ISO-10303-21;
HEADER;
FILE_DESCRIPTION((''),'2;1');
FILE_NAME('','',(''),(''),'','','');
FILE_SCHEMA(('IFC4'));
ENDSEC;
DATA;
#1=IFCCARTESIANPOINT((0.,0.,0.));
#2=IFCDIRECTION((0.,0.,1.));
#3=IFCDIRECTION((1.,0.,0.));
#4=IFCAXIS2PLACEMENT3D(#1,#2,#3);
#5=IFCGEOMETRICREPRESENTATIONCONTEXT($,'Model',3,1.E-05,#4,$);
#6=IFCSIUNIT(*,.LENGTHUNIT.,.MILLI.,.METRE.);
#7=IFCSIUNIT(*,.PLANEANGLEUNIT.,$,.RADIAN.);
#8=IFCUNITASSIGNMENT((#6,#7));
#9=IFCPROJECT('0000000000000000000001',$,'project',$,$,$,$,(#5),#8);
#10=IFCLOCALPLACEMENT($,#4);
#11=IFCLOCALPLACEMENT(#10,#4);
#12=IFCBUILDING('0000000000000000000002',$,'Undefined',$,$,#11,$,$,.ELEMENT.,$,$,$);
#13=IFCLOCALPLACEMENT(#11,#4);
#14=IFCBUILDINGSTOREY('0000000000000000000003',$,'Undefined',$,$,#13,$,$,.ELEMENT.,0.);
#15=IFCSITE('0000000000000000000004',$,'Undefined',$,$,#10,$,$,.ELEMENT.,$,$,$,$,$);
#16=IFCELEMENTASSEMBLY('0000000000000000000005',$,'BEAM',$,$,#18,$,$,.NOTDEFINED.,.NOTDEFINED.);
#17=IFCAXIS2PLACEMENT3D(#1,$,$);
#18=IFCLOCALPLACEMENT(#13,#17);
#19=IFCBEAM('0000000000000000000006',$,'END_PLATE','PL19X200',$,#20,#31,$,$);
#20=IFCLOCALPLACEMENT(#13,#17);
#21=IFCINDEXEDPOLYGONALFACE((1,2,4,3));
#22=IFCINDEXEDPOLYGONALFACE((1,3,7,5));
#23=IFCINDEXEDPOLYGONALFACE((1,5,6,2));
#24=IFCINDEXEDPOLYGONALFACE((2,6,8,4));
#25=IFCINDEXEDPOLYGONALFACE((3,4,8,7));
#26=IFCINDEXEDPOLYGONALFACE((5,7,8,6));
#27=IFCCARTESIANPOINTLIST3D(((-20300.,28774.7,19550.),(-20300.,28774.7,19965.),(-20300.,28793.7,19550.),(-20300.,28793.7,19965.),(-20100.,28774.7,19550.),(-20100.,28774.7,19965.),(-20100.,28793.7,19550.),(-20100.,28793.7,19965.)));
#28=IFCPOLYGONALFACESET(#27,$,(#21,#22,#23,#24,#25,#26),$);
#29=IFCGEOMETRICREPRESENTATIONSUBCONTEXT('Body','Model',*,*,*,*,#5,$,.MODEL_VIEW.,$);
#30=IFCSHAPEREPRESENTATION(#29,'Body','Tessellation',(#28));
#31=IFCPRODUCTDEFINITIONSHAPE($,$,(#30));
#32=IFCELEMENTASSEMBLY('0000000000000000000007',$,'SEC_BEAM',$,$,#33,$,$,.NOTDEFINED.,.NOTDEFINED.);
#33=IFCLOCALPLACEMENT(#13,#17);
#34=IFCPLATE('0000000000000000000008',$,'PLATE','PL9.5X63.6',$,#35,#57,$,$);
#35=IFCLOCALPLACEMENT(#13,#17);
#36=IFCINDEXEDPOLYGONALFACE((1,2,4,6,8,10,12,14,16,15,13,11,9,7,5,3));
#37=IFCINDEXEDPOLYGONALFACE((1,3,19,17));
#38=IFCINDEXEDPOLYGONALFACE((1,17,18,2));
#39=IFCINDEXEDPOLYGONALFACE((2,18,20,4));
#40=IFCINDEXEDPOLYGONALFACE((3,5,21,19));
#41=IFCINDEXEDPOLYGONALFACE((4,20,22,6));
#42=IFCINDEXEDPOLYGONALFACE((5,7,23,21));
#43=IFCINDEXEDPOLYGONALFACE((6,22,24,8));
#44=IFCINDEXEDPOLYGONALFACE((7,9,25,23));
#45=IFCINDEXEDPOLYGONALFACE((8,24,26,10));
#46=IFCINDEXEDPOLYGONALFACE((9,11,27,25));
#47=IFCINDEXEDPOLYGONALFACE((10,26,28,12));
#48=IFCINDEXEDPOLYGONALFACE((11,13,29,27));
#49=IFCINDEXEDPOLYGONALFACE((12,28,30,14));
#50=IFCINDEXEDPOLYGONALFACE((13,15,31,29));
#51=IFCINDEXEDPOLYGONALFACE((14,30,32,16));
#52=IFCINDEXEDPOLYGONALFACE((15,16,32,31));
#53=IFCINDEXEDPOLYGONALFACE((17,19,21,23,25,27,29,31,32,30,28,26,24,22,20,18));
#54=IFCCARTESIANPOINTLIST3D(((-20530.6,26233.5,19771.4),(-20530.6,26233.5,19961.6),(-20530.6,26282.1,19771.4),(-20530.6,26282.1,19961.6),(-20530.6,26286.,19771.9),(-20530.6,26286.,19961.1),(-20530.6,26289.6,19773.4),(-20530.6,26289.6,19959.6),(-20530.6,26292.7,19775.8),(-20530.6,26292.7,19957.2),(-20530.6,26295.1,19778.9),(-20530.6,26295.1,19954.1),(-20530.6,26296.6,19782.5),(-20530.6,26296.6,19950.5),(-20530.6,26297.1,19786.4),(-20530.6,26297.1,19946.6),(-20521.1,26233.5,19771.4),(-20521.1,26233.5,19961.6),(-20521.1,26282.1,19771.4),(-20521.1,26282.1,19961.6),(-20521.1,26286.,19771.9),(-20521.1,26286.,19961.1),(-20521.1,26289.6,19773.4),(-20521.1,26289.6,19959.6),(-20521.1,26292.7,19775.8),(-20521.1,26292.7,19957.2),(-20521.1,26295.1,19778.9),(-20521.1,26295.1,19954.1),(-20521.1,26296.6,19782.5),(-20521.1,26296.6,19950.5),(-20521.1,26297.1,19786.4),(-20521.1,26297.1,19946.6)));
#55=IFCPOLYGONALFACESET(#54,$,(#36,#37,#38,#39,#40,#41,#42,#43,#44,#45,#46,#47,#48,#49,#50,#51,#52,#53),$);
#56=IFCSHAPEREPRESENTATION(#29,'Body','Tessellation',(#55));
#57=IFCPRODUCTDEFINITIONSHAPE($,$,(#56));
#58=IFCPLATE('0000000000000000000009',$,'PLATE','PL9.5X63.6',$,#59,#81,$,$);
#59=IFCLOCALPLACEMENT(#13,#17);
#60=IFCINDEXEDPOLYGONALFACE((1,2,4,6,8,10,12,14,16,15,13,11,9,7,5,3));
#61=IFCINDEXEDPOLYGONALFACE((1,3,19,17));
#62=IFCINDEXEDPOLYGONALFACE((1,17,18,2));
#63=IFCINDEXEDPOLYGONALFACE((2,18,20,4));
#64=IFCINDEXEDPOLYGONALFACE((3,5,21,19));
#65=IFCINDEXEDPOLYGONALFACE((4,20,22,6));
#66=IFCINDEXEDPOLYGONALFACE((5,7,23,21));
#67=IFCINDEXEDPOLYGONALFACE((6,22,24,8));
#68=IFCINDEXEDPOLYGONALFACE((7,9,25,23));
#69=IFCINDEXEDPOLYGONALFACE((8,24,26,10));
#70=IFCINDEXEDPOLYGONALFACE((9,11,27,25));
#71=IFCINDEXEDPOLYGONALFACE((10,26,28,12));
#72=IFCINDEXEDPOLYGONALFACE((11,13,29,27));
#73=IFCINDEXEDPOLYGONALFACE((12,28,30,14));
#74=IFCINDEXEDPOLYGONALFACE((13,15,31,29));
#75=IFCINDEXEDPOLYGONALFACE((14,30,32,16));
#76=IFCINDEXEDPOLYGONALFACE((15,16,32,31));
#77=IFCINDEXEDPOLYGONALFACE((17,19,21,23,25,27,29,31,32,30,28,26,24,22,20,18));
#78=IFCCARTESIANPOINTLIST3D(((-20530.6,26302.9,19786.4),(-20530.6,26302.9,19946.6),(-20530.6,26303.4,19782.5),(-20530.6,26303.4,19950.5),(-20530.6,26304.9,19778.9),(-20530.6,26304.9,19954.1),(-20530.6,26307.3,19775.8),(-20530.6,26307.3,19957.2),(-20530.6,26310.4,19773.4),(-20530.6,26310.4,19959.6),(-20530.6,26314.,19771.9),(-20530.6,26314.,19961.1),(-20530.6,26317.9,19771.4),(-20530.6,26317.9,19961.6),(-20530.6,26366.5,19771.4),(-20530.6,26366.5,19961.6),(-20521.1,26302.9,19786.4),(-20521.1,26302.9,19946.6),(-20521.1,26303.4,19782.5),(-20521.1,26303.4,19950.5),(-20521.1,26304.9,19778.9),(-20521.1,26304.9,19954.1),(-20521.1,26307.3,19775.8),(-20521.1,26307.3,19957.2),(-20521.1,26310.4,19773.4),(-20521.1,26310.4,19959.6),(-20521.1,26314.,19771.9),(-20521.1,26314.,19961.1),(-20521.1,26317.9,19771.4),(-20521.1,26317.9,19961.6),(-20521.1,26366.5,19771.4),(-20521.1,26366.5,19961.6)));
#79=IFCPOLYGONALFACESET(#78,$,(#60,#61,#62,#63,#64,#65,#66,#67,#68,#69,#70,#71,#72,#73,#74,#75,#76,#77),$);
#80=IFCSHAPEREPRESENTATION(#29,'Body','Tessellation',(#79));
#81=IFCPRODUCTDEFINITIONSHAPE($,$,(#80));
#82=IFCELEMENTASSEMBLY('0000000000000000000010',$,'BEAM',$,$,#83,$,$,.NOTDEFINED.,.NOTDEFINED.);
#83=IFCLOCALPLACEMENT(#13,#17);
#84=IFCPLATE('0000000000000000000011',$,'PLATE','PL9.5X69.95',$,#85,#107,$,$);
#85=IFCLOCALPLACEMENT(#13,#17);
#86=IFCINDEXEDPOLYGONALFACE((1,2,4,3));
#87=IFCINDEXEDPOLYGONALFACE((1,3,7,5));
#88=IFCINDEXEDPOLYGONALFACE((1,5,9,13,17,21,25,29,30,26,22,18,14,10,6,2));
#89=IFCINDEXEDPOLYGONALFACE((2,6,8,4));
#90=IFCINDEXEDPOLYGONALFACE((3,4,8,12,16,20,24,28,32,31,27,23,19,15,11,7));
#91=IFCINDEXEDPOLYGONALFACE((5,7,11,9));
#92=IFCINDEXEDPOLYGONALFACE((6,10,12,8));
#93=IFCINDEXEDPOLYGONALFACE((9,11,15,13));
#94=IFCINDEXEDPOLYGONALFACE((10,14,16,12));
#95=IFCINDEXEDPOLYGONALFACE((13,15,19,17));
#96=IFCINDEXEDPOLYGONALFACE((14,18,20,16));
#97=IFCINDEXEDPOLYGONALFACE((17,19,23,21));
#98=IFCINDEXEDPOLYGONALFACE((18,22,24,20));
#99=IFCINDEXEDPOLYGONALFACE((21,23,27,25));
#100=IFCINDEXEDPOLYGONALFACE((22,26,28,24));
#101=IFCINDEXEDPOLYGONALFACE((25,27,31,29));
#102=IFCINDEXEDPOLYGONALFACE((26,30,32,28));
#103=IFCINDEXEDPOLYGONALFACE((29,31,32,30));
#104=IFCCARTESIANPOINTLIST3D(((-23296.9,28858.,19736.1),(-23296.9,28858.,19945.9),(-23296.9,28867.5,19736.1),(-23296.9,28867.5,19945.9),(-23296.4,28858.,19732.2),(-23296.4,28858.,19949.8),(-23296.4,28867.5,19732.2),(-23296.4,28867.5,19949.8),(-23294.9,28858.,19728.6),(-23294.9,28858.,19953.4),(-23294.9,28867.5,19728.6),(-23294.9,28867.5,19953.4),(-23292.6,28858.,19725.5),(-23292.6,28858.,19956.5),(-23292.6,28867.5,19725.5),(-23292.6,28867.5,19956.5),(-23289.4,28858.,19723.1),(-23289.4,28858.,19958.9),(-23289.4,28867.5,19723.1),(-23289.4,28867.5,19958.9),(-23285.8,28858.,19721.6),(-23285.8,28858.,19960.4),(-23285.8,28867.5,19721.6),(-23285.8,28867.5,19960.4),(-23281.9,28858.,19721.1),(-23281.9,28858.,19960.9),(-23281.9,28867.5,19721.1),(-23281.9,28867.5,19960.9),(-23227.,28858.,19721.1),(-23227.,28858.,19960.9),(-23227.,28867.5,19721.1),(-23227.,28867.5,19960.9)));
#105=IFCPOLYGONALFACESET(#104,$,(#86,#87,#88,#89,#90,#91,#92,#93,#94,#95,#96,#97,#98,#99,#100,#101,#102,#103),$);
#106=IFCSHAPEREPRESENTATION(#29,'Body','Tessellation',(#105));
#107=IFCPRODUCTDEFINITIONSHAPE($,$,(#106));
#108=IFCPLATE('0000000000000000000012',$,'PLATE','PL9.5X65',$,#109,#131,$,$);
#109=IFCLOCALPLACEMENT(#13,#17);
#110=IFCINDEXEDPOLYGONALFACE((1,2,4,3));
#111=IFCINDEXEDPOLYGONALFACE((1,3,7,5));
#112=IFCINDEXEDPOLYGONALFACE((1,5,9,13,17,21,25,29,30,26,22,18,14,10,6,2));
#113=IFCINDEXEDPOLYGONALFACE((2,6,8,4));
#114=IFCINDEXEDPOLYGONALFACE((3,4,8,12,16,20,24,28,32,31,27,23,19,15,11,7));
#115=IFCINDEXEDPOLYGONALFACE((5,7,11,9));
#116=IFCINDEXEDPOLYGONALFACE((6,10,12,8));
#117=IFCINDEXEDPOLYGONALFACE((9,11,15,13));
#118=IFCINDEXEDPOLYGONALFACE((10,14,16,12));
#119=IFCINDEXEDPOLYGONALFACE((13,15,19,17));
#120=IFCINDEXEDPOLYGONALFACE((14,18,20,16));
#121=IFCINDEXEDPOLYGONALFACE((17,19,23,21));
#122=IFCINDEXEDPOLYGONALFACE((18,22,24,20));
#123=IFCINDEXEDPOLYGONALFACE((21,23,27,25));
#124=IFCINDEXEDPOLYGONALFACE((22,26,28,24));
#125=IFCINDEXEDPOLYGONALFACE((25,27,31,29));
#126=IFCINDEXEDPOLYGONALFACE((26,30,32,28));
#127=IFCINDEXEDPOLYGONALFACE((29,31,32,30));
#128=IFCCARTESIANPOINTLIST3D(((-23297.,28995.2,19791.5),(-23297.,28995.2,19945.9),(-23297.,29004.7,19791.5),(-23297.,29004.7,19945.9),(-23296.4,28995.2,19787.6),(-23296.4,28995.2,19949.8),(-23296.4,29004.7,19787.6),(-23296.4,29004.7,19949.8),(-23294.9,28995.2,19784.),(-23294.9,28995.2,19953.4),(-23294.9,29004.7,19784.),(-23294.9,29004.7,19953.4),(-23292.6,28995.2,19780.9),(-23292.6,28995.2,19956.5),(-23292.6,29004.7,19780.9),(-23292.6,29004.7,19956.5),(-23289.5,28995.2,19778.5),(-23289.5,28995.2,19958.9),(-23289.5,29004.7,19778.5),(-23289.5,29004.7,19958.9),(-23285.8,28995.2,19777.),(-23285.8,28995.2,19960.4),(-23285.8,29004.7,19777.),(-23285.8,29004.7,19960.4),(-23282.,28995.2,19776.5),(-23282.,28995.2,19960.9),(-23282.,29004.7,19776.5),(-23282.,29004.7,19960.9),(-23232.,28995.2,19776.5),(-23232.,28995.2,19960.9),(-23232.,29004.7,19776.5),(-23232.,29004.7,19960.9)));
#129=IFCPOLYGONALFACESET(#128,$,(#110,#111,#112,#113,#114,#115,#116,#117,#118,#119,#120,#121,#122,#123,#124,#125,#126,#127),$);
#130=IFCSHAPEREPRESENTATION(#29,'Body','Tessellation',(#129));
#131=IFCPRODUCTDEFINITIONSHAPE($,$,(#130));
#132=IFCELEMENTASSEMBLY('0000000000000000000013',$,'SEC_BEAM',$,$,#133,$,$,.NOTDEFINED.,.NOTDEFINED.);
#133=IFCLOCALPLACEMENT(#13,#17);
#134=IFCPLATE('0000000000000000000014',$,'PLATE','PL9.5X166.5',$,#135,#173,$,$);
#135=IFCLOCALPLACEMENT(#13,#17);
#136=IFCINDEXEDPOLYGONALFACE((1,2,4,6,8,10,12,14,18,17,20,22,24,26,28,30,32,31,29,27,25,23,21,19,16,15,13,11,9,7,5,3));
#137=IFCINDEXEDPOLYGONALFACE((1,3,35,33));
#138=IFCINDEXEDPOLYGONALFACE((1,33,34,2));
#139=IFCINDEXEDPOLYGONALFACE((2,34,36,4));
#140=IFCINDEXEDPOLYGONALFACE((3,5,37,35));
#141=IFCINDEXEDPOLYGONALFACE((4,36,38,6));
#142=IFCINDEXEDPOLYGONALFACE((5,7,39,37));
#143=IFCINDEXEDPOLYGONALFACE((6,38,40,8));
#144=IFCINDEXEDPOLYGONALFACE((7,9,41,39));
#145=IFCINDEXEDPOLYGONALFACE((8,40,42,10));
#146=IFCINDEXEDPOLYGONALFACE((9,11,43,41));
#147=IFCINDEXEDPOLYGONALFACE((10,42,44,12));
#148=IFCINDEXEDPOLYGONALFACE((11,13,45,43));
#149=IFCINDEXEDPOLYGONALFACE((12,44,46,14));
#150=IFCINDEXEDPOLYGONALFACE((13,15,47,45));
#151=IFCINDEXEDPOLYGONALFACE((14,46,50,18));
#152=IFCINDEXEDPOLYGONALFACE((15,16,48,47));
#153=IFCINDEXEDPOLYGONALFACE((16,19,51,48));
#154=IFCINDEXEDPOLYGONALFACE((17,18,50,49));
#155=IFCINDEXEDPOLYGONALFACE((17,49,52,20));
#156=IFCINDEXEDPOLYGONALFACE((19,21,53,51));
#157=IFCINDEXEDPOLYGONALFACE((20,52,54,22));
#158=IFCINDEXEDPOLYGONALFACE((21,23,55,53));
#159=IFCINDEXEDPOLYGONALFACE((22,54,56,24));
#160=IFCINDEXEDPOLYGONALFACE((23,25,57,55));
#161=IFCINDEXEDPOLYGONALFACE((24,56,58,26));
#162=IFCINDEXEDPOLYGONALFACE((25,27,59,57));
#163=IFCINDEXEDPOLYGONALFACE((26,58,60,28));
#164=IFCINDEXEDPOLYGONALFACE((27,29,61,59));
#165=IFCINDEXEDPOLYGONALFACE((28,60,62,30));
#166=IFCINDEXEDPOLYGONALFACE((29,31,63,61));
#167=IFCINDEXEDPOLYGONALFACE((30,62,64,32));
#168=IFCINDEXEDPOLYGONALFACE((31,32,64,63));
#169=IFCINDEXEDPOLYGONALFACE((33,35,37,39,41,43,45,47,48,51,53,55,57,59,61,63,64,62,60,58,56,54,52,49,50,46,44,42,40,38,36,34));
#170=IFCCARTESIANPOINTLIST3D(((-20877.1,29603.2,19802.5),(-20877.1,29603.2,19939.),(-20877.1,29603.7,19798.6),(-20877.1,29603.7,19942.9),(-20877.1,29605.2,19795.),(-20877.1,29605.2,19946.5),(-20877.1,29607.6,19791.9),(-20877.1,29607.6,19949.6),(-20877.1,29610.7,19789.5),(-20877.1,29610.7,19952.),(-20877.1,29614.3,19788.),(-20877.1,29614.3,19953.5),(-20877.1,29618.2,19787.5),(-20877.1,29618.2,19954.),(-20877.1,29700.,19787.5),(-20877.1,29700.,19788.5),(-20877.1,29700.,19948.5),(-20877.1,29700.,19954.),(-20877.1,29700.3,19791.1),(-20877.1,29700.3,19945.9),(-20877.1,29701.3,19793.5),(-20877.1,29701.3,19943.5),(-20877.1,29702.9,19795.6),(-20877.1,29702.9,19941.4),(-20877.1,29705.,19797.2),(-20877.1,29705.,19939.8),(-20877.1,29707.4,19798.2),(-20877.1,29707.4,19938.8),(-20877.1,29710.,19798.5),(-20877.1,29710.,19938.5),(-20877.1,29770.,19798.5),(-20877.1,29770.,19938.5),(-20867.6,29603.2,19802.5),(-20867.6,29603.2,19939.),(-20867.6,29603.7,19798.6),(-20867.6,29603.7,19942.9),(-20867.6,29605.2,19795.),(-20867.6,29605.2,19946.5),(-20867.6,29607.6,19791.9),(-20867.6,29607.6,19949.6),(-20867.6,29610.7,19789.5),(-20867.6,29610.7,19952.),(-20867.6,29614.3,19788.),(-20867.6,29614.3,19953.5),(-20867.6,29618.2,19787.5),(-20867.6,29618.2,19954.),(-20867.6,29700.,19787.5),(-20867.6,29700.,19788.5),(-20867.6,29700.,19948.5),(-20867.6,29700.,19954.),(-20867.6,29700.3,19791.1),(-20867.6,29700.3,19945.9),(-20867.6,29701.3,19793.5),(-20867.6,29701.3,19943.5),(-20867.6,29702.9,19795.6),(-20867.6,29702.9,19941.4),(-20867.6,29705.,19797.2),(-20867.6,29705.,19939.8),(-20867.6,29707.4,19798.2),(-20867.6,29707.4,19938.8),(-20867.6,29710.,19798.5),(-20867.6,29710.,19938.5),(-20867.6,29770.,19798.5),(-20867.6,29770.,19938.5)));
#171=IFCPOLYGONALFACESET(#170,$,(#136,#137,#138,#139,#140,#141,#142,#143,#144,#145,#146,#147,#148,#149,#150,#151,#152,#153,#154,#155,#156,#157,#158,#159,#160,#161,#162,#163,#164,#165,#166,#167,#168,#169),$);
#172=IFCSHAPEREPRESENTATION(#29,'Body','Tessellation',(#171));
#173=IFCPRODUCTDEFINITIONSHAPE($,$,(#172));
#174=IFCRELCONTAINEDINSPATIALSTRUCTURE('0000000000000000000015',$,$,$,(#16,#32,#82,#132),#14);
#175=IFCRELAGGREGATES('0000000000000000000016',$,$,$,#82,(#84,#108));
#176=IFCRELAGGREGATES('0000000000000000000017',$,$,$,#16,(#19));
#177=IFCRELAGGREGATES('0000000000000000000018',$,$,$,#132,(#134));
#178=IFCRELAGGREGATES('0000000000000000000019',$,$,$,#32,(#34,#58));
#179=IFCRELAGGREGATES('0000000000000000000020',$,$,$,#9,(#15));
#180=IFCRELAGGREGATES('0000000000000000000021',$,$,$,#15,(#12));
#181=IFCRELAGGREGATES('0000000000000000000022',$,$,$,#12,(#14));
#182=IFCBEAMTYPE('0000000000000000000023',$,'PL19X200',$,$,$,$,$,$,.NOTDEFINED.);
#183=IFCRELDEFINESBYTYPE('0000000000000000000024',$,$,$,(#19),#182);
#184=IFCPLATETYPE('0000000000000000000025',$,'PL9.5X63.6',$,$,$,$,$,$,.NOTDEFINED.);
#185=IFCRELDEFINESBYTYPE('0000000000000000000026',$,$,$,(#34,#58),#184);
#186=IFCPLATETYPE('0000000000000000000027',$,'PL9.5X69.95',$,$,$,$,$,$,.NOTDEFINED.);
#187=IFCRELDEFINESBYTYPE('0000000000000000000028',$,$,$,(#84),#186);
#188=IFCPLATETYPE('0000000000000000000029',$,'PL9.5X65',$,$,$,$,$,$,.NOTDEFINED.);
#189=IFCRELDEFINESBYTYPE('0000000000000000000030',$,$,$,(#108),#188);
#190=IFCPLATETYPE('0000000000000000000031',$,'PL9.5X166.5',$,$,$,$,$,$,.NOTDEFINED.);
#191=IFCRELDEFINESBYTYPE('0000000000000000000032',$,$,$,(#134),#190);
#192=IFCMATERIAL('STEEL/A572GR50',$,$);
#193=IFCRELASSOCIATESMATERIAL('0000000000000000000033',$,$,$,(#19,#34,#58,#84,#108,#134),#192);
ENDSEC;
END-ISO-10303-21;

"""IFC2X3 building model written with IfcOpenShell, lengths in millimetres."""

from ifc_helpers import new_model, si_unit, frame, frame_2d, origin_with_axes, origin_2d_with_axis, place, context, subcontext, project, spatial, polyline, circle_curve, parameter, trimmed, segment, composite_curve, rectangle, outline, extrude, material, type_object, element, aggregate, save


model = new_model("IFC2X3")

# Units and contexts
model_context = context("Model", 3, precision=1e-05, world=origin_with_axes())
body_context = subcontext(model_context, "Body", "Model", "MODEL_VIEW")
ifc_project = project(units=[si_unit("LENGTHUNIT", "METRE", prefix="MILLI"), si_unit("PLANEANGLEUNIT", "RADIAN")], contexts=[model_context])

# Site, building, storey
site_placement = place(None, origin_with_axes())
site = spatial("IfcSite", under=ifc_project, at=site_placement, Name="Undefined", CompositionType="ELEMENT")
building_placement = place(site_placement, origin_with_axes())
building = spatial("IfcBuilding", under=site, at=building_placement, Name="Undefined", CompositionType="ELEMENT")
storey_placement = place(building_placement, origin_with_axes())
storey = spatial("IfcBuildingStorey", under=building, at=storey_placement, Name="Undefined", CompositionType="ELEMENT", Elevation=0.0)

# Element assemblies, beam
assembly_1_placement = place(storey_placement, origin_with_axes())
assembly_1 = element("IfcElementAssembly", 1, at=assembly_1_placement, inside=storey, Name="BEAM", AssemblyPlace="NOTDEFINED", PredefinedType="NOTDEFINED")
ifc_material_1 = material(Name="STEEL/A572GR50")
beam_type_1 = type_object("IfcBeamType", Name="PL19X200", PredefinedType="NOTDEFINED")
beam_1_placement = place(assembly_1_placement, frame((-20200.0, 28784.2, 19965.0), z_axis=(-1.0, 0.0, 0.0), x_axis=(0.0, 0.0, -1.0)))
beam_1 = element("IfcBeam", 2, at=beam_1_placement, type_object=beam_type_1, material=ifc_material_1, Name="END_PLATE", Description="PL19X200", context=body_context, shape_type="SweptSolid", body=[
    extrude(rectangle(XDim=19.0, YDim=200.0, at=origin_2d_with_axis()), frame((415.0, 0.0, 0.0), z_axis=(-1.0, 0.0, 0.0), x_axis=(0.0, -1.0, 0.0)), (0.0, 0.0, 1.0), 415.0),
])
assembly_2_placement = place(storey_placement, origin_with_axes())
assembly_2 = element("IfcElementAssembly", 3, at=assembly_2_placement, inside=storey, Name="SEC_BEAM", AssemblyPlace="NOTDEFINED", PredefinedType="NOTDEFINED")

# Plates
plate_type_1 = type_object("IfcPlateType", Name="PL9.5X63.6", PredefinedType="NOTDEFINED")
plate_1_placement = place(assembly_2_placement, frame((-20525.8, 26233.5, 19771.4), z_axis=(1.0, 0.0, 0.0), x_axis=(0.0, 1.0, 0.0)))
plate_1 = element("IfcPlate", 4, at=plate_1_placement, type_object=plate_type_1, material=ifc_material_1, Name="PLATE", Description="PL9.5X63.6", context=body_context, shape_type="SweptSolid", body=[
    extrude(outline(composite_curve([segment(polyline([(0.0, 0.0), (48.6, 0.0)]), True, "CONTINUOUS"), segment(trimmed(circle_curve(frame_2d((48.6, 15.0), x_axis=(0.0, -1.0)), 15.0), [parameter(0.0)], [parameter(1.570796)], True, "PARAMETER"), True, "CONTINUOUS"), segment(polyline([(63.6, 15.0), (63.6, 175.2)]), True, "CONTINUOUS"), segment(trimmed(circle_curve(frame_2d((48.6, 175.2), x_axis=(1.0, 0.0)), 15.0), [parameter(0.0)], [parameter(1.570796)], True, "PARAMETER"), True, "CONTINUOUS"), segment(polyline([(48.6, 190.2), (0.0, 190.2), (0.0, 0.0)]), True, "CONTINUOUS")], self_intersect=True)), frame((0.0, 0.0, -4.8), z_axis=(0.0, 0.0, 1.0), x_axis=(1.0, 0.0, 0.0)), (0.0, 0.0, 1.0), 9.5),
])
plate_2_placement = place(assembly_2_placement, frame((-20525.8, 26302.9, 19771.4), z_axis=(1.0, 0.0, 0.0), x_axis=(0.0, 1.0, 0.0)))
plate_2 = element("IfcPlate", 5, at=plate_2_placement, type_object=plate_type_1, material=ifc_material_1, Name="PLATE", Description="PL9.5X63.6", context=body_context, shape_type="SweptSolid", body=[
    extrude(outline(composite_curve([segment(trimmed(circle_curve(frame_2d((15.0, 15.0), x_axis=(-1.0, 0.0)), 15.0), [parameter(0.0)], [parameter(1.570796)], True, "PARAMETER"), True, "CONTINUOUS"), segment(polyline([(15.0, 0.0), (63.6, 0.0), (63.6, 190.2), (15.0, 190.2)]), True, "CONTINUOUS"), segment(trimmed(circle_curve(frame_2d((15.0, 175.2), x_axis=(0.0, 1.0)), 15.0), [parameter(0.0)], [parameter(1.570796)], True, "PARAMETER"), True, "CONTINUOUS"), segment(polyline([(0.0, 175.2), (0.0, 15.0)]), True, "CONTINUOUS")], self_intersect=True)), frame((0.0, 0.0, -4.8), z_axis=(0.0, 0.0, 1.0), x_axis=(1.0, 0.0, 0.0)), (0.0, 0.0, 1.0), 9.5),
])

# Element assemblies, plates
assembly_3_placement = place(storey_placement, origin_with_axes())
assembly_3 = element("IfcElementAssembly", 6, at=assembly_3_placement, inside=storey, Name="BEAM", AssemblyPlace="NOTDEFINED", PredefinedType="NOTDEFINED")
plate_type_2 = type_object("IfcPlateType", Name="PL9.5X69.95", PredefinedType="NOTDEFINED")
plate_3_placement = place(assembly_3_placement, frame((-23227.0, 28862.8, 19721.1), z_axis=(0.0, 1.0, 0.0), x_axis=(-1.0, 0.0, 0.0)))
plate_3 = element("IfcPlate", 7, at=plate_3_placement, type_object=plate_type_2, material=ifc_material_1, Name="PLATE", Description="PL9.5X69.95", context=body_context, shape_type="SweptSolid", body=[
    extrude(outline(composite_curve([segment(polyline([(0.0, 0.0), (54.9, 0.0)]), True, "CONTINUOUS"), segment(trimmed(circle_curve(frame_2d((54.9, 15.0), x_axis=(0.0, -1.0)), 15.0), [parameter(0.0)], [parameter(1.570796)], True, "PARAMETER"), True, "CONTINUOUS"), segment(polyline([(69.9, 15.0), (69.9, 224.8)]), True, "CONTINUOUS"), segment(trimmed(circle_curve(frame_2d((54.9, 224.8), x_axis=(1.0, 0.0)), 15.0), [parameter(0.0)], [parameter(1.570796)], True, "PARAMETER"), True, "CONTINUOUS"), segment(polyline([(54.9, 239.8), (0.0, 239.8), (0.0, 0.0)]), True, "CONTINUOUS")], self_intersect=True)), frame((0.0, 0.0, -4.8), z_axis=(0.0, 0.0, 1.0), x_axis=(1.0, 0.0, 0.0)), (0.0, 0.0, 1.0), 9.5),
])
plate_type_3 = type_object("IfcPlateType", Name="PL9.5X65", PredefinedType="NOTDEFINED")
plate_4_placement = place(assembly_3_placement, frame((-23232.0, 29000.0, 19776.5), z_axis=(0.0, 1.0, 0.0), x_axis=(-1.0, 0.0, 0.0)))
plate_4 = element("IfcPlate", 8, at=plate_4_placement, type_object=plate_type_3, material=ifc_material_1, Name="PLATE", Description="PL9.5X65", context=body_context, shape_type="SweptSolid", body=[
    extrude(outline(composite_curve([segment(polyline([(0.0, 0.0), (50.0, 0.0)]), True, "CONTINUOUS"), segment(trimmed(circle_curve(frame_2d((50.0, 15.0), x_axis=(0.0, -1.0)), 15.0), [parameter(0.0)], [parameter(1.570796)], True, "PARAMETER"), True, "CONTINUOUS"), segment(polyline([(65.0, 15.0), (65.0, 169.4)]), True, "CONTINUOUS"), segment(trimmed(circle_curve(frame_2d((50.0, 169.4), x_axis=(1.0, 0.0)), 15.0), [parameter(0.0)], [parameter(1.570796)], True, "PARAMETER"), True, "CONTINUOUS"), segment(polyline([(50.0, 184.4), (0.0, 184.4), (0.0, 0.0)]), True, "CONTINUOUS")], self_intersect=True)), frame((0.0, 0.0, -4.8), z_axis=(0.0, 0.0, 1.0), x_axis=(1.0, 0.0, 0.0)), (0.0, 0.0, 1.0), 9.5),
])
aggregate(assembly_3, [plate_3, plate_4])
assembly_4_placement = place(storey_placement, origin_with_axes())
assembly_4 = element("IfcElementAssembly", 9, at=assembly_4_placement, inside=storey, Name="SEC_BEAM", AssemblyPlace="NOTDEFINED", PredefinedType="NOTDEFINED")
plate_type_4 = type_object("IfcPlateType", Name="PL9.5X166.5", PredefinedType="NOTDEFINED")
plate_5_placement = place(assembly_4_placement, frame((-20872.3, 29603.2, 19954.0), z_axis=(1.0, 0.0, 0.0), x_axis=(0.0, 0.0, -1.0)))
plate_5 = element("IfcPlate", 10, at=plate_5_placement, type_object=plate_type_4, material=ifc_material_1, Name="PLATE", Description="PL9.5X166.5", context=body_context, shape_type="SweptSolid", body=[
    extrude(outline(composite_curve([segment(trimmed(circle_curve(frame_2d((15.0, 15.0), x_axis=(-1.0, 0.0)), 15.0), [parameter(0.0)], [parameter(1.570796)], True, "PARAMETER"), True, "CONTINUOUS"), segment(polyline([(15.0, 0.0), (151.5, 0.0)]), True, "CONTINUOUS"), segment(trimmed(circle_curve(frame_2d((151.5, 15.0), x_axis=(0.0, -1.0)), 15.0), [parameter(0.0)], [parameter(1.570796)], True, "PARAMETER"), True, "CONTINUOUS"), segment(polyline([(166.5, 15.0), (166.5, 96.8), (165.5, 96.8)]), True, "CONTINUOUS"), segment(trimmed(circle_curve(frame_2d((165.5, 106.8), x_axis=(0.0, -1.0)), 10.0), [parameter(0.0)], [parameter(4.712389)], False, "PARAMETER"), True, "CONTINUOUS"), segment(polyline([(155.5, 106.8), (155.5, 166.8), (15.5, 166.8), (15.5, 106.8)]), True, "CONTINUOUS"), segment(trimmed(circle_curve(frame_2d((5.5, 106.8), x_axis=(1.0, 0.0)), 10.0), [parameter(0.0)], [parameter(4.712389)], False, "PARAMETER"), True, "CONTINUOUS"), segment(polyline([(5.5, 96.8), (0.0, 96.8), (0.0, 15.0)]), True, "CONTINUOUS")], self_intersect=True)), frame((0.0, 0.0, -4.8), z_axis=(0.0, 0.0, 1.0), x_axis=(1.0, 0.0, 0.0)), (0.0, 0.0, 1.0), 9.5),
])

aggregate(assembly_1, [beam_1])
aggregate(assembly_4, [plate_5])
aggregate(assembly_2, [plate_1, plate_2])

save(model, "model.ifc")
